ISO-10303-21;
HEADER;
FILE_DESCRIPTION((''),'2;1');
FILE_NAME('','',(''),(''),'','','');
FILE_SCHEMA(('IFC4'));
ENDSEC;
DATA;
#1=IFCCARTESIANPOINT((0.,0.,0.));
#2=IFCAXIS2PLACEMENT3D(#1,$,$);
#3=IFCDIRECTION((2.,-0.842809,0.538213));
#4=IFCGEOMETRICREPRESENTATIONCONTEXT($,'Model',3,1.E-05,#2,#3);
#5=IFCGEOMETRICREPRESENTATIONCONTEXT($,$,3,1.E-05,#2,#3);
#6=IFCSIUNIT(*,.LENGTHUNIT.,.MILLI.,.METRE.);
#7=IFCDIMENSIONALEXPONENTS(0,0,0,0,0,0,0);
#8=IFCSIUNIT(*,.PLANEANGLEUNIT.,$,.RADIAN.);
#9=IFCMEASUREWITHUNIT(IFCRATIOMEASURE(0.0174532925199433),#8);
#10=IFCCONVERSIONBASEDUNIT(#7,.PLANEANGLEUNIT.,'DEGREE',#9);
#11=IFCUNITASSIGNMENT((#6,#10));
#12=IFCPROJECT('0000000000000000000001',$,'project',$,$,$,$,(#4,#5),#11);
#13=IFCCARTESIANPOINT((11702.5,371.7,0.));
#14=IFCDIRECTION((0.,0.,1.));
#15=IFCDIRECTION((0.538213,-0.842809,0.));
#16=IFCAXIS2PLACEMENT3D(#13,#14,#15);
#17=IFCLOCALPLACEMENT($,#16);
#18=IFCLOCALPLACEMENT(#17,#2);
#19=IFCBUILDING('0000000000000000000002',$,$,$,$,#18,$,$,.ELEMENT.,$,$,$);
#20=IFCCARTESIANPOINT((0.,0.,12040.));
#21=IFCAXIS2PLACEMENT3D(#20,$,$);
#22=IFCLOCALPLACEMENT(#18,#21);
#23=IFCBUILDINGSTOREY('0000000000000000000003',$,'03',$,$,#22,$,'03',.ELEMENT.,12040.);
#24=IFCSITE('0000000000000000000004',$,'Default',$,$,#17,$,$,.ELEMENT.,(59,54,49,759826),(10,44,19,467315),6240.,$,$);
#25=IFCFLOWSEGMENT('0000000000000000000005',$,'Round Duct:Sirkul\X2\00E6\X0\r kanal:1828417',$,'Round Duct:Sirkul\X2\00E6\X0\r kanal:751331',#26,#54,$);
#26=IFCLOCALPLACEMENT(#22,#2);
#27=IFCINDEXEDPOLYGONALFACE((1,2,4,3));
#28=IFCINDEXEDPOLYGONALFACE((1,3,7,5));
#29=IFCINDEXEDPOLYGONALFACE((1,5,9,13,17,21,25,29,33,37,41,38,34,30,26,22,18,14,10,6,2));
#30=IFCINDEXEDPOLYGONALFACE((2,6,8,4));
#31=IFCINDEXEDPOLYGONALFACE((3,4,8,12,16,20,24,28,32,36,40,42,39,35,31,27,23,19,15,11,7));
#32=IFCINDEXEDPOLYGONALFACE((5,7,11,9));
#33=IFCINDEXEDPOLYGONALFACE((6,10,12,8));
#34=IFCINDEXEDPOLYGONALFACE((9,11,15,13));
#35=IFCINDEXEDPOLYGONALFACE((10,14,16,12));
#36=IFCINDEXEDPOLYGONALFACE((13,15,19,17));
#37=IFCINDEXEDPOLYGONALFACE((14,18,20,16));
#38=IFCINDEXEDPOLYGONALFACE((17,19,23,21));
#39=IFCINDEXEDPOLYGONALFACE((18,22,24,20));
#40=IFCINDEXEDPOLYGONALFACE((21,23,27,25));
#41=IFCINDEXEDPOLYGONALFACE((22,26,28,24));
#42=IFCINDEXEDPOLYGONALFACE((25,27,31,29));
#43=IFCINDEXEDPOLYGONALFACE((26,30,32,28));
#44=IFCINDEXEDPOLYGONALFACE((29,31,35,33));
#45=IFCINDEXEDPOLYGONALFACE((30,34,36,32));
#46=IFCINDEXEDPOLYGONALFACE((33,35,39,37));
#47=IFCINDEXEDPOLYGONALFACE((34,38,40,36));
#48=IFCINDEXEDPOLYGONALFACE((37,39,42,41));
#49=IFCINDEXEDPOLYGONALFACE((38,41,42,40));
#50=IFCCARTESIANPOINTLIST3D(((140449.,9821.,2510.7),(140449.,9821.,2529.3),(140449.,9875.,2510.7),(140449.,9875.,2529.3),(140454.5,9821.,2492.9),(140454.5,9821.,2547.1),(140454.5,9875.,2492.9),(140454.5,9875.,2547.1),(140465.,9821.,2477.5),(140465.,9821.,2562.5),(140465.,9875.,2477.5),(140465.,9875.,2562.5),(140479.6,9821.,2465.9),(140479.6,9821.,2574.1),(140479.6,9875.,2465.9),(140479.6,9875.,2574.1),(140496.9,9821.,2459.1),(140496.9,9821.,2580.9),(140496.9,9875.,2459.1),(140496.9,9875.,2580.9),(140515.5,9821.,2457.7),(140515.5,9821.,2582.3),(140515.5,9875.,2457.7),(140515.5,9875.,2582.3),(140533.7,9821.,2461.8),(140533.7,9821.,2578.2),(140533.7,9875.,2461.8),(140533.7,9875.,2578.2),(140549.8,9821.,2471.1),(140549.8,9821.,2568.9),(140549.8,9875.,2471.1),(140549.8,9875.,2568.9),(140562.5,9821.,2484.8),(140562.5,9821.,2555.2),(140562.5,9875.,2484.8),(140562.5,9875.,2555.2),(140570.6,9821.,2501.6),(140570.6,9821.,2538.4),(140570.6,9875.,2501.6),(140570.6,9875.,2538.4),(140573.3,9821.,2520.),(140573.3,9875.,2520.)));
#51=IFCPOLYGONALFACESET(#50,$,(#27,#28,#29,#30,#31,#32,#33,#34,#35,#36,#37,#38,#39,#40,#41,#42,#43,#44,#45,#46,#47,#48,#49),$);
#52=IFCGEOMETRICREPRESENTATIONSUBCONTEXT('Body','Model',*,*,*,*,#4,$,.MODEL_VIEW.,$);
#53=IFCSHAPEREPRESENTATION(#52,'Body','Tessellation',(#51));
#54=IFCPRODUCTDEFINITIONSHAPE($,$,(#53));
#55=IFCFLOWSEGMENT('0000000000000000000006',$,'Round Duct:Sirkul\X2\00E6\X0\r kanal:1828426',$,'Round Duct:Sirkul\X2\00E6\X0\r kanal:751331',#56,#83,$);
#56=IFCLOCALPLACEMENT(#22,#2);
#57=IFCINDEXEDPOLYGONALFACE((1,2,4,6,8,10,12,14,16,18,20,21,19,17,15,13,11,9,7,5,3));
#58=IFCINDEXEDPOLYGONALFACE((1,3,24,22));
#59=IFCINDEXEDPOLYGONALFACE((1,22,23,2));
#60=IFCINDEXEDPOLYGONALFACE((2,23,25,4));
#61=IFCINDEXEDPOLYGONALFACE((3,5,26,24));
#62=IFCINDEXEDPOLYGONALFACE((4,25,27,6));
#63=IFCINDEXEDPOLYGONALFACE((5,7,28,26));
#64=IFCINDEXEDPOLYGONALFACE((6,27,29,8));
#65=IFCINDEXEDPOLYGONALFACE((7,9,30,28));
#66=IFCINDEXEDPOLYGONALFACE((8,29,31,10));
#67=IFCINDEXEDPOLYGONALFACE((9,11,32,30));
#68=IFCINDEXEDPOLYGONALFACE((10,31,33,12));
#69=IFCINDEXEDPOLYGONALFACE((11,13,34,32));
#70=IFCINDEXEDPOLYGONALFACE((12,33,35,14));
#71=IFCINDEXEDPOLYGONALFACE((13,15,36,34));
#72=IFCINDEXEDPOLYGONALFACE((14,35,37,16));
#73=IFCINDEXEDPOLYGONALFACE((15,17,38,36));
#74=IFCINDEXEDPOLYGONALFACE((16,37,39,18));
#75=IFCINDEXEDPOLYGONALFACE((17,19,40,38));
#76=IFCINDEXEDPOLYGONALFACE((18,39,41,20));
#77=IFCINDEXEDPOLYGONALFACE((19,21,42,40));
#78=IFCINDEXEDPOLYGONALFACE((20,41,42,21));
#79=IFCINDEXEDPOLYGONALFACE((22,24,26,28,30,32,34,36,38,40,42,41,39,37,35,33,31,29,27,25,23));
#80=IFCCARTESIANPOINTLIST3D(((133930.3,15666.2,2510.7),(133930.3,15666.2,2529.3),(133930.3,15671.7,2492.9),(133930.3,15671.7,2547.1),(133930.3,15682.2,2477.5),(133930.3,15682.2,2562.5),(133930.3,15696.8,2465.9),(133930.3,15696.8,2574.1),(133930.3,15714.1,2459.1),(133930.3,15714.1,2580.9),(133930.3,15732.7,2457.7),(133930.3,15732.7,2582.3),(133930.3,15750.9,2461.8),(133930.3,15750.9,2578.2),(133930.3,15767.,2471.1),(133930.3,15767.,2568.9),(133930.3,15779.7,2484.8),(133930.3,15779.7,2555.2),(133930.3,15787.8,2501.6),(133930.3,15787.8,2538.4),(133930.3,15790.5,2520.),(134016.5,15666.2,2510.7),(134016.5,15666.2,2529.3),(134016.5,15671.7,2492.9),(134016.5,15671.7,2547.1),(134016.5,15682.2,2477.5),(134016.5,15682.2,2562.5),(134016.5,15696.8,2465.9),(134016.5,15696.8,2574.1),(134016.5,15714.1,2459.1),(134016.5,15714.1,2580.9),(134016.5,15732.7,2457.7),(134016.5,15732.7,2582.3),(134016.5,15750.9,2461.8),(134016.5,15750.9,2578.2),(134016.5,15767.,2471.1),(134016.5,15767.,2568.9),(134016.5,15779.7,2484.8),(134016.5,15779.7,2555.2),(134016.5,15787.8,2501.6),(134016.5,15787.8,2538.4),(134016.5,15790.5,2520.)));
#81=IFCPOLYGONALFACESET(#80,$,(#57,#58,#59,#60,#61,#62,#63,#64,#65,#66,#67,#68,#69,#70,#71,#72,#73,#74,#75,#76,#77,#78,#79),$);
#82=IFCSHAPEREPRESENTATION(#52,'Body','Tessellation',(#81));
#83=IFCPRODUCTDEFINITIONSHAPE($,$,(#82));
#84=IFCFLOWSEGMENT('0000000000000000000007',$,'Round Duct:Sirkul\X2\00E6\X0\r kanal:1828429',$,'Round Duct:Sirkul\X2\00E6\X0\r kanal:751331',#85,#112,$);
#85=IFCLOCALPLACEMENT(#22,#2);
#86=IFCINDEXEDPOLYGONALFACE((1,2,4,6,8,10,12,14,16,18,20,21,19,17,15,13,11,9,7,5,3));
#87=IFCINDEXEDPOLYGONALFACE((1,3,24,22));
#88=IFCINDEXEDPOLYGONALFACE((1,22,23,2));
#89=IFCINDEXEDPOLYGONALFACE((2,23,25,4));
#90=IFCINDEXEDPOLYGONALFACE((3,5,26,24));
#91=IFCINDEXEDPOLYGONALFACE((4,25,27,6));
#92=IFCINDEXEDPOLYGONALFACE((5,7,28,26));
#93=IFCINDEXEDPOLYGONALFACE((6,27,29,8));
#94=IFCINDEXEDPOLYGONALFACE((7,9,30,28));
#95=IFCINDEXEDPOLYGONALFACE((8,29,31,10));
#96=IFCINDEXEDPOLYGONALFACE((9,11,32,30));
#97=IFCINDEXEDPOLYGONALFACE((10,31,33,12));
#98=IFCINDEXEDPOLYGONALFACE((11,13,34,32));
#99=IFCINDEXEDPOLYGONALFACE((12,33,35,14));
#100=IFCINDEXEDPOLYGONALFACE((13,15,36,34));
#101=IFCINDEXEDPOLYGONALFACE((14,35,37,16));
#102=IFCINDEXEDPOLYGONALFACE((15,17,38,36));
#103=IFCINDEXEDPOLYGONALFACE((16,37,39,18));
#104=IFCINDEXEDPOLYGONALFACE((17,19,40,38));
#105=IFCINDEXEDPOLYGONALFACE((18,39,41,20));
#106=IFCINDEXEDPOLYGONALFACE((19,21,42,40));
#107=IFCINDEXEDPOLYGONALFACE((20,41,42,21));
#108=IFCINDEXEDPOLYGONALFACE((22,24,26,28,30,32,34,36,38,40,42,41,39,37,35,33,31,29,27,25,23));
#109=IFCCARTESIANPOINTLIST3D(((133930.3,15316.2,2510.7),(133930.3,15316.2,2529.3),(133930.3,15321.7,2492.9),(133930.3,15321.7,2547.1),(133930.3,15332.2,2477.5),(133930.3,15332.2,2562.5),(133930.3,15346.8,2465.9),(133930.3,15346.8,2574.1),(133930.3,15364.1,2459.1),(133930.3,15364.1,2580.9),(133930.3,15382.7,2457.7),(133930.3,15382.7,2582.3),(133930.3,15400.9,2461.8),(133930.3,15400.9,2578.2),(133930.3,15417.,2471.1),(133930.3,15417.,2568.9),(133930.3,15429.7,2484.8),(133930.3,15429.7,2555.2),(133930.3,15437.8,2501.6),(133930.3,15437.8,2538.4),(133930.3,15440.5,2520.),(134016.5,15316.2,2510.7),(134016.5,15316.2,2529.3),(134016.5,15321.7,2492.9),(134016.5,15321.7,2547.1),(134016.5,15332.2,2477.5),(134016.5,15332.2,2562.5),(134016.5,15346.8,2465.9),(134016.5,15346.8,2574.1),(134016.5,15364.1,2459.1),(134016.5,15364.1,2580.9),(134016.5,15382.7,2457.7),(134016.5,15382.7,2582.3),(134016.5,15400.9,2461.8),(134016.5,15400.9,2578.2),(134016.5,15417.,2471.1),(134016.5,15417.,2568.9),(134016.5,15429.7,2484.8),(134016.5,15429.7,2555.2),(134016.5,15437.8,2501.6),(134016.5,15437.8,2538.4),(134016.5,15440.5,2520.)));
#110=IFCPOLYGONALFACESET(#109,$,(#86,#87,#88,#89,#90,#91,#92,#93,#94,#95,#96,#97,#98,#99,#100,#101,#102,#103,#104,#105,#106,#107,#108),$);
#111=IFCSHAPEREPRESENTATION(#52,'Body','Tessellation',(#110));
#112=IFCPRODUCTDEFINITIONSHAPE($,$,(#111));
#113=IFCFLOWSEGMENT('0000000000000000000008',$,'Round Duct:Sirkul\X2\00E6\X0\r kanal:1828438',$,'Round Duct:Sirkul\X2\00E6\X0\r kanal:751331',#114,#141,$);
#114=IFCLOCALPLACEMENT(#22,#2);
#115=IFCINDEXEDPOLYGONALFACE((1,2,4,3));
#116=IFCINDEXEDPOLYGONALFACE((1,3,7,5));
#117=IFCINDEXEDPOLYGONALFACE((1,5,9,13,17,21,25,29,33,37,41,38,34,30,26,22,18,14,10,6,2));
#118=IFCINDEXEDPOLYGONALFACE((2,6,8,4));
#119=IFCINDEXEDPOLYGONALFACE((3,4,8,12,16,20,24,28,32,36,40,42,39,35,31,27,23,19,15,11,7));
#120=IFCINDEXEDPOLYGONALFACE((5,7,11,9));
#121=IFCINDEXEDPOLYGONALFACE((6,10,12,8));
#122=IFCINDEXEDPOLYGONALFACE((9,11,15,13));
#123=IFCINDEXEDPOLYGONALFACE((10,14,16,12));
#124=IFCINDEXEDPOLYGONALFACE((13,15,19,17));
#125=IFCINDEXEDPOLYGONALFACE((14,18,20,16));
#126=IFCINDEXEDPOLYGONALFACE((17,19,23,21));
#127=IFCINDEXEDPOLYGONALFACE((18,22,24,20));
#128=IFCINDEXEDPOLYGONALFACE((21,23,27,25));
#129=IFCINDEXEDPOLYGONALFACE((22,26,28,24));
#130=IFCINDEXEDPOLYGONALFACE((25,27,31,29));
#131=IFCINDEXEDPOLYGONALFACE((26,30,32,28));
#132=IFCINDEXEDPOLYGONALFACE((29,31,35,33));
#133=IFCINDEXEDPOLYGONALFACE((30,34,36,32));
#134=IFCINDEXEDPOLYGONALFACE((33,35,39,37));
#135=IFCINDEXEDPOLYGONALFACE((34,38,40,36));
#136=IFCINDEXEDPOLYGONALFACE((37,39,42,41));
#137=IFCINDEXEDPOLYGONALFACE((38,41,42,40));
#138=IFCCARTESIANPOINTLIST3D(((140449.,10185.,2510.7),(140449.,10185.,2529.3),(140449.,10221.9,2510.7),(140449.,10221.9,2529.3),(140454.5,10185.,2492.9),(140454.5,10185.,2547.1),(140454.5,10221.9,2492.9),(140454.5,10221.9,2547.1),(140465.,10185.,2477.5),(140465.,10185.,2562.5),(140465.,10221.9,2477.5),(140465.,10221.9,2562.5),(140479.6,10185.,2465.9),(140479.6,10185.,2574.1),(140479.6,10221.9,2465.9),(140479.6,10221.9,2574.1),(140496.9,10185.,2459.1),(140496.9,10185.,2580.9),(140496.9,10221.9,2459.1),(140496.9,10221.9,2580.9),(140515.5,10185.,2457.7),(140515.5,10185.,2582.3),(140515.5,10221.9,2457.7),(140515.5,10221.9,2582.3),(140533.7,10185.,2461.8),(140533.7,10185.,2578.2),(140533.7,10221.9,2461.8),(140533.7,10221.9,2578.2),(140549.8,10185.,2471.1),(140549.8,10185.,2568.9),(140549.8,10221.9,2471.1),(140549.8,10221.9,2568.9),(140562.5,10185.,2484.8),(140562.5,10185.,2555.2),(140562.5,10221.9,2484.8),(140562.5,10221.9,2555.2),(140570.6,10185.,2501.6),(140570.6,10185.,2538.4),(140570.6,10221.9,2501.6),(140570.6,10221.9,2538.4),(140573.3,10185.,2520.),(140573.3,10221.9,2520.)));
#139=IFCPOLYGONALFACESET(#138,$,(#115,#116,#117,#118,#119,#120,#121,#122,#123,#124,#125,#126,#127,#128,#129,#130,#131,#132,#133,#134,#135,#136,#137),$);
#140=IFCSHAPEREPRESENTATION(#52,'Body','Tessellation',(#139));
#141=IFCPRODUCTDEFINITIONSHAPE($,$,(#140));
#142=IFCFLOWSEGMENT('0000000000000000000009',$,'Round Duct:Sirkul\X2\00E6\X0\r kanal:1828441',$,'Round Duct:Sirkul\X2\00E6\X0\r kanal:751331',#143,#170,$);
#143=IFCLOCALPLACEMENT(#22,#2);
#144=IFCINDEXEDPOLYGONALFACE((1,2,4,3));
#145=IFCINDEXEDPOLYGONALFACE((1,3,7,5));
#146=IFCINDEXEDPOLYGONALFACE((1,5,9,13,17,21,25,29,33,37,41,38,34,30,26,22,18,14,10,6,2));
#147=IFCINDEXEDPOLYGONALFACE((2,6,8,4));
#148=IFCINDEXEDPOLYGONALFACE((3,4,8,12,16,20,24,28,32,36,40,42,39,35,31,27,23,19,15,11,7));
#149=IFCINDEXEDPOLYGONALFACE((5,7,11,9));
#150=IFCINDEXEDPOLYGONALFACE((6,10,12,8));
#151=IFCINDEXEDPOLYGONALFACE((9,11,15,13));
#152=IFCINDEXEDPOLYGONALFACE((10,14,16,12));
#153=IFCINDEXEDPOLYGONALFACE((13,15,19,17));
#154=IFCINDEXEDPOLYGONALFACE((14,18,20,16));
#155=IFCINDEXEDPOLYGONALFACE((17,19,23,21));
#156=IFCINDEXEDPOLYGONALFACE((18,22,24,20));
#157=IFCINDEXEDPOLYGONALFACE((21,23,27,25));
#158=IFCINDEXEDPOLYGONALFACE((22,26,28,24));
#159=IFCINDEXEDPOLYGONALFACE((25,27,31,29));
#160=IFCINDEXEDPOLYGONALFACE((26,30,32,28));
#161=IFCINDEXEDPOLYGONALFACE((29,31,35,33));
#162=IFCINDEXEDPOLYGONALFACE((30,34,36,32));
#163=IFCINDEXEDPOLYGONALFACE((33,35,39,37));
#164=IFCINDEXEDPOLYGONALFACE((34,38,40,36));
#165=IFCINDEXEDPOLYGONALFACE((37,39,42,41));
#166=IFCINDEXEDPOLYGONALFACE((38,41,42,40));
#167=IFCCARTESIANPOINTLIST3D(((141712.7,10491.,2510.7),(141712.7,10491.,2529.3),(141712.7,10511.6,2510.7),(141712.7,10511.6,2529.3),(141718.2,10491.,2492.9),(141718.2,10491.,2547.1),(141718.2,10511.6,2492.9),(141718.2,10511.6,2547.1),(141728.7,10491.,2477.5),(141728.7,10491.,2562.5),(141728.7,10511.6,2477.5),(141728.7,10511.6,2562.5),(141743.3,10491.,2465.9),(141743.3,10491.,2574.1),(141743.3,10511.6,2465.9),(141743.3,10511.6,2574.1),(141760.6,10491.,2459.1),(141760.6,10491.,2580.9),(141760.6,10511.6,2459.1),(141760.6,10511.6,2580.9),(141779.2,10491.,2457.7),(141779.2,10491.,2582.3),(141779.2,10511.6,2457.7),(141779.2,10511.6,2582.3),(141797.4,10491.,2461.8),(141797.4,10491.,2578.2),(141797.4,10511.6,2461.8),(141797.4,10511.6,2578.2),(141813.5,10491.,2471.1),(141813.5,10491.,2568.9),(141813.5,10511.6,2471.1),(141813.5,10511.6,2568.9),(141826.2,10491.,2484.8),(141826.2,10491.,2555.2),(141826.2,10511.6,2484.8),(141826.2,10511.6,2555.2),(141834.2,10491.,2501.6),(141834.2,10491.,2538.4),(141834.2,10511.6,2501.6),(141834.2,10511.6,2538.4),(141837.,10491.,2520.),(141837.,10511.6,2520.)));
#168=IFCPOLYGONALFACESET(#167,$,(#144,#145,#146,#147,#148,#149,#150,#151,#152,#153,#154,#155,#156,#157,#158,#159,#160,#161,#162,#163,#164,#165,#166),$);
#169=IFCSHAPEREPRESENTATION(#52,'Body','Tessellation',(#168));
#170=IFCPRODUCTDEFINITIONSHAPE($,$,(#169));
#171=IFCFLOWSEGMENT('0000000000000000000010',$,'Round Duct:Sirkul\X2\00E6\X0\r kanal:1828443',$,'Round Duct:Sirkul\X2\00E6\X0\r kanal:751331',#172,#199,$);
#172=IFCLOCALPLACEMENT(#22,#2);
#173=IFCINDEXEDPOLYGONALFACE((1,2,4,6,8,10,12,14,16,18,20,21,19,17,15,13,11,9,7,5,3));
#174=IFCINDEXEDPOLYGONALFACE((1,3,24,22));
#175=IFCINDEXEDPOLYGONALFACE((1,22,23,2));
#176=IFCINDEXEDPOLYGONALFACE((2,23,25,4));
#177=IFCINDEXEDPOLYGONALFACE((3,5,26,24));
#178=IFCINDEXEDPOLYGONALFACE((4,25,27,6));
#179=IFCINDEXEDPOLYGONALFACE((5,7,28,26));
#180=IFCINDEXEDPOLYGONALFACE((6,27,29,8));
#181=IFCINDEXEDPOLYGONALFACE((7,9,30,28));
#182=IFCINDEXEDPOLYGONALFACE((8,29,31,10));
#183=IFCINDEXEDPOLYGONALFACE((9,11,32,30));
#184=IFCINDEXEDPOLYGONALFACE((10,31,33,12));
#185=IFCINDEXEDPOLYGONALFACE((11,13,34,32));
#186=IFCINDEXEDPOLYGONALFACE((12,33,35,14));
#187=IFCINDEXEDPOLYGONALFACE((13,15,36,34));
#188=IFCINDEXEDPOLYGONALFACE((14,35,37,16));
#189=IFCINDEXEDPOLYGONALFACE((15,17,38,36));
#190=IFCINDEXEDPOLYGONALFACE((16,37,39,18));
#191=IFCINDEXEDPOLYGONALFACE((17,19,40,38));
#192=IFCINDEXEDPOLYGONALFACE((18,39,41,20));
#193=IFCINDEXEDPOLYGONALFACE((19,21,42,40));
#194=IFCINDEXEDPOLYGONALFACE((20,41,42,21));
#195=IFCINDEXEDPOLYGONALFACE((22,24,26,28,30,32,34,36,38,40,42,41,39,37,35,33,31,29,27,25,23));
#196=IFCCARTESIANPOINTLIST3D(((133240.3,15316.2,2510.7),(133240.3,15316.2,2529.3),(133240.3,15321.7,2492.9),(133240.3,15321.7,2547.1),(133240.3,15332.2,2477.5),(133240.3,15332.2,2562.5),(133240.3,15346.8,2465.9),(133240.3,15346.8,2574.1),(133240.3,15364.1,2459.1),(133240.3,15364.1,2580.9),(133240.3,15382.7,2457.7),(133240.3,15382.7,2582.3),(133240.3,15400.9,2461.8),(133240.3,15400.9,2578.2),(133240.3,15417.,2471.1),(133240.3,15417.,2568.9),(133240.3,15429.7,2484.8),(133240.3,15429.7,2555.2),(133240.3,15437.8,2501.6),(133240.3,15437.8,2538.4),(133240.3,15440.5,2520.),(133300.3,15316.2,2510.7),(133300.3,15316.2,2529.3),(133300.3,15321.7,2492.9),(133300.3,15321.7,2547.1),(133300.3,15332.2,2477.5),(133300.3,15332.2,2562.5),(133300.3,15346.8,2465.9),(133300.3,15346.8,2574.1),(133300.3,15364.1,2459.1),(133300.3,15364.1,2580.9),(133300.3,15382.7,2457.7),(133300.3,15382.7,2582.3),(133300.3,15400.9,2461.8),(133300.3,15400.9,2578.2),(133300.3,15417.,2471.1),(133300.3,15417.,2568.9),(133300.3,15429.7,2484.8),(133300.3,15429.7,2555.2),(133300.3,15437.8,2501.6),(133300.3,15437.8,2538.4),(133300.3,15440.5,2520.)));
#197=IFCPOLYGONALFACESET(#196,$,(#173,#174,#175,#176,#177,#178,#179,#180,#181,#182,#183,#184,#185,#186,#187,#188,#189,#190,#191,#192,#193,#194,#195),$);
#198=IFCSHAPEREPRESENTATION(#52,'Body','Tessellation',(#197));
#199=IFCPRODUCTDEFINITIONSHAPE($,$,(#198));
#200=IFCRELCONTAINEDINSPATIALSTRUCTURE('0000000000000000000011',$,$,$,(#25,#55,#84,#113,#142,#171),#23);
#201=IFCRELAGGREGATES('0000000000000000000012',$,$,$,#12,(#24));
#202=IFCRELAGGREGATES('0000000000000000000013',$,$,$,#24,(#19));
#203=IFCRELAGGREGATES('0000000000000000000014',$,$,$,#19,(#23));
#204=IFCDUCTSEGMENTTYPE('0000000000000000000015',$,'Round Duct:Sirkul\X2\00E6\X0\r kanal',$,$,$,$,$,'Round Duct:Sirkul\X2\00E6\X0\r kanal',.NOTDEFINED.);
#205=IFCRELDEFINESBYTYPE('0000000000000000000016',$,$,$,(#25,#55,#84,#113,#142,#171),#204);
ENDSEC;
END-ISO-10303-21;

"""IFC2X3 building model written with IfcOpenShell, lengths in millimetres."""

from ifc_helpers import new_model, entity, si_unit, converted_unit, direction, frame, frame_2d, origin, origin_2d_with_axis, place, context, subcontext, project, spatial, circle, extrude, type_object, element, save


model = new_model("IFC2X3")

# Units and contexts
model_context = context("Model", 3, precision=1e-05, world=origin(), true_north=direction((2.0, -0.842809, 0.538213)))
context_of_model = context(None, 3, precision=1e-05, world=origin(), true_north=direction((2.0, -0.842809, 0.538213)))
body_context = subcontext(model_context, "Body", "Model", "MODEL_VIEW")
ifc_project = project(units=[si_unit("LENGTHUNIT", "METRE", prefix="MILLI"), converted_unit("PLANEANGLEUNIT", "DEGREE", entity("IfcRatioMeasure", 0.0174532925199433), si_unit("PLANEANGLEUNIT", "RADIAN"), dimensions=[0, 0, 0, 0, 0, 0, 0])], contexts=[model_context, context_of_model])

# Site, building, storey
site_placement = place(None, frame((11702.5, 371.7, 0.0), z_axis=(0.0, 0.0, 1.0), x_axis=(0.538213, -0.842809, 0.0)))
site = spatial("IfcSite", under=ifc_project, at=site_placement, Name="Default", CompositionType="ELEMENT", RefLatitude=(59, 54, 49, 759826), RefLongitude=(10, 44, 19, 467315), RefElevation=6240.0)
building_placement = place(site_placement, origin())
building = spatial("IfcBuilding", under=site, at=building_placement, CompositionType="ELEMENT")
storey_placement = place(building_placement, frame((0.0, 0.0, 12040.0)))
storey = spatial("IfcBuildingStorey", under=building, at=storey_placement, Name="03", LongName="03", CompositionType="ELEMENT", Elevation=12040.0)

# Flow segments
duct_segment_type_1 = type_object("IfcDuctSegmentType", Name="Round Duct:Sirkulær kanal", ElementType="Round Duct:Sirkulær kanal", PredefinedType="NOTDEFINED")
flow_segment_1_placement = place(storey_placement, origin())
element("IfcFlowSegment", 1, at=flow_segment_1_placement, inside=storey, type_object=duct_segment_type_1, Name="Round Duct:Sirkulær kanal:1828417", ObjectType="Round Duct:Sirkulær kanal:751331", context=body_context, shape_type="SweptSolid", body=[
    extrude(circle(Radius=62.5, at=frame_2d((0.0, 0.0), x_axis=(1.0, 0.0))), frame((140510.8, 9821.0, 2520.0), z_axis=(0.0, 1.0, 0.0), x_axis=(1.0, 0.0, 0.0)), (0.0, 0.0, 1.0), 54.0),
])
flow_segment_2_placement = place(storey_placement, origin())
element("IfcFlowSegment", 2, at=flow_segment_2_placement, inside=storey, type_object=duct_segment_type_1, Name="Round Duct:Sirkulær kanal:1828426", ObjectType="Round Duct:Sirkulær kanal:751331", context=body_context, shape_type="SweptSolid", body=[
    extrude(circle(Radius=62.5, at=origin_2d_with_axis()), frame((133930.3, 15728.0, 2520.0), z_axis=(1.0, 0.0, 0.0), x_axis=(0.0, 1.0, 0.0)), (0.0, 0.0, 1.0), 86.2),
])
flow_segment_3_placement = place(storey_placement, origin())
element("IfcFlowSegment", 3, at=flow_segment_3_placement, inside=storey, type_object=duct_segment_type_1, Name="Round Duct:Sirkulær kanal:1828429", ObjectType="Round Duct:Sirkulær kanal:751331", context=body_context, shape_type="SweptSolid", body=[
    extrude(circle(Radius=62.5, at=origin_2d_with_axis()), frame((133930.3, 15378.0, 2520.0), z_axis=(1.0, 0.0, 0.0), x_axis=(0.0, 1.0, 0.0)), (0.0, 0.0, 1.0), 86.2),
])
flow_segment_4_placement = place(storey_placement, origin())
element("IfcFlowSegment", 4, at=flow_segment_4_placement, inside=storey, type_object=duct_segment_type_1, Name="Round Duct:Sirkulær kanal:1828438", ObjectType="Round Duct:Sirkulær kanal:751331", context=body_context, shape_type="SweptSolid", body=[
    extrude(circle(Radius=62.5, at=frame_2d((0.0, 0.0), x_axis=(1.0, 0.0))), frame((140510.8, 10185.0, 2520.0), z_axis=(0.0, 1.0, 0.0), x_axis=(1.0, 0.0, 0.0)), (0.0, 0.0, 1.0), 36.9),
])
flow_segment_5_placement = place(storey_placement, origin())
element("IfcFlowSegment", 5, at=flow_segment_5_placement, inside=storey, type_object=duct_segment_type_1, Name="Round Duct:Sirkulær kanal:1828441", ObjectType="Round Duct:Sirkulær kanal:751331", context=body_context, shape_type="SweptSolid", body=[
    extrude(circle(Radius=62.5, at=frame_2d((0.0, 0.0), x_axis=(1.0, 0.0))), frame((141774.5, 10491.0, 2520.0), z_axis=(0.0, 1.0, 0.0), x_axis=(1.0, 0.0, 0.0)), (0.0, 0.0, 1.0), 20.6),
])
flow_segment_6_placement = place(storey_placement, origin())
element("IfcFlowSegment", 6, at=flow_segment_6_placement, inside=storey, type_object=duct_segment_type_1, Name="Round Duct:Sirkulær kanal:1828443", ObjectType="Round Duct:Sirkulær kanal:751331", context=body_context, shape_type="SweptSolid", body=[
    extrude(circle(Radius=62.5, at=frame_2d((0.0, 0.0), x_axis=(1.0, 0.0))), frame((133240.3, 15378.0, 2520.0), z_axis=(1.0, 0.0, 0.0), x_axis=(0.0, 1.0, 0.0)), (0.0, 0.0, 1.0), 60.0),
])

save(model, "model.ifc")
